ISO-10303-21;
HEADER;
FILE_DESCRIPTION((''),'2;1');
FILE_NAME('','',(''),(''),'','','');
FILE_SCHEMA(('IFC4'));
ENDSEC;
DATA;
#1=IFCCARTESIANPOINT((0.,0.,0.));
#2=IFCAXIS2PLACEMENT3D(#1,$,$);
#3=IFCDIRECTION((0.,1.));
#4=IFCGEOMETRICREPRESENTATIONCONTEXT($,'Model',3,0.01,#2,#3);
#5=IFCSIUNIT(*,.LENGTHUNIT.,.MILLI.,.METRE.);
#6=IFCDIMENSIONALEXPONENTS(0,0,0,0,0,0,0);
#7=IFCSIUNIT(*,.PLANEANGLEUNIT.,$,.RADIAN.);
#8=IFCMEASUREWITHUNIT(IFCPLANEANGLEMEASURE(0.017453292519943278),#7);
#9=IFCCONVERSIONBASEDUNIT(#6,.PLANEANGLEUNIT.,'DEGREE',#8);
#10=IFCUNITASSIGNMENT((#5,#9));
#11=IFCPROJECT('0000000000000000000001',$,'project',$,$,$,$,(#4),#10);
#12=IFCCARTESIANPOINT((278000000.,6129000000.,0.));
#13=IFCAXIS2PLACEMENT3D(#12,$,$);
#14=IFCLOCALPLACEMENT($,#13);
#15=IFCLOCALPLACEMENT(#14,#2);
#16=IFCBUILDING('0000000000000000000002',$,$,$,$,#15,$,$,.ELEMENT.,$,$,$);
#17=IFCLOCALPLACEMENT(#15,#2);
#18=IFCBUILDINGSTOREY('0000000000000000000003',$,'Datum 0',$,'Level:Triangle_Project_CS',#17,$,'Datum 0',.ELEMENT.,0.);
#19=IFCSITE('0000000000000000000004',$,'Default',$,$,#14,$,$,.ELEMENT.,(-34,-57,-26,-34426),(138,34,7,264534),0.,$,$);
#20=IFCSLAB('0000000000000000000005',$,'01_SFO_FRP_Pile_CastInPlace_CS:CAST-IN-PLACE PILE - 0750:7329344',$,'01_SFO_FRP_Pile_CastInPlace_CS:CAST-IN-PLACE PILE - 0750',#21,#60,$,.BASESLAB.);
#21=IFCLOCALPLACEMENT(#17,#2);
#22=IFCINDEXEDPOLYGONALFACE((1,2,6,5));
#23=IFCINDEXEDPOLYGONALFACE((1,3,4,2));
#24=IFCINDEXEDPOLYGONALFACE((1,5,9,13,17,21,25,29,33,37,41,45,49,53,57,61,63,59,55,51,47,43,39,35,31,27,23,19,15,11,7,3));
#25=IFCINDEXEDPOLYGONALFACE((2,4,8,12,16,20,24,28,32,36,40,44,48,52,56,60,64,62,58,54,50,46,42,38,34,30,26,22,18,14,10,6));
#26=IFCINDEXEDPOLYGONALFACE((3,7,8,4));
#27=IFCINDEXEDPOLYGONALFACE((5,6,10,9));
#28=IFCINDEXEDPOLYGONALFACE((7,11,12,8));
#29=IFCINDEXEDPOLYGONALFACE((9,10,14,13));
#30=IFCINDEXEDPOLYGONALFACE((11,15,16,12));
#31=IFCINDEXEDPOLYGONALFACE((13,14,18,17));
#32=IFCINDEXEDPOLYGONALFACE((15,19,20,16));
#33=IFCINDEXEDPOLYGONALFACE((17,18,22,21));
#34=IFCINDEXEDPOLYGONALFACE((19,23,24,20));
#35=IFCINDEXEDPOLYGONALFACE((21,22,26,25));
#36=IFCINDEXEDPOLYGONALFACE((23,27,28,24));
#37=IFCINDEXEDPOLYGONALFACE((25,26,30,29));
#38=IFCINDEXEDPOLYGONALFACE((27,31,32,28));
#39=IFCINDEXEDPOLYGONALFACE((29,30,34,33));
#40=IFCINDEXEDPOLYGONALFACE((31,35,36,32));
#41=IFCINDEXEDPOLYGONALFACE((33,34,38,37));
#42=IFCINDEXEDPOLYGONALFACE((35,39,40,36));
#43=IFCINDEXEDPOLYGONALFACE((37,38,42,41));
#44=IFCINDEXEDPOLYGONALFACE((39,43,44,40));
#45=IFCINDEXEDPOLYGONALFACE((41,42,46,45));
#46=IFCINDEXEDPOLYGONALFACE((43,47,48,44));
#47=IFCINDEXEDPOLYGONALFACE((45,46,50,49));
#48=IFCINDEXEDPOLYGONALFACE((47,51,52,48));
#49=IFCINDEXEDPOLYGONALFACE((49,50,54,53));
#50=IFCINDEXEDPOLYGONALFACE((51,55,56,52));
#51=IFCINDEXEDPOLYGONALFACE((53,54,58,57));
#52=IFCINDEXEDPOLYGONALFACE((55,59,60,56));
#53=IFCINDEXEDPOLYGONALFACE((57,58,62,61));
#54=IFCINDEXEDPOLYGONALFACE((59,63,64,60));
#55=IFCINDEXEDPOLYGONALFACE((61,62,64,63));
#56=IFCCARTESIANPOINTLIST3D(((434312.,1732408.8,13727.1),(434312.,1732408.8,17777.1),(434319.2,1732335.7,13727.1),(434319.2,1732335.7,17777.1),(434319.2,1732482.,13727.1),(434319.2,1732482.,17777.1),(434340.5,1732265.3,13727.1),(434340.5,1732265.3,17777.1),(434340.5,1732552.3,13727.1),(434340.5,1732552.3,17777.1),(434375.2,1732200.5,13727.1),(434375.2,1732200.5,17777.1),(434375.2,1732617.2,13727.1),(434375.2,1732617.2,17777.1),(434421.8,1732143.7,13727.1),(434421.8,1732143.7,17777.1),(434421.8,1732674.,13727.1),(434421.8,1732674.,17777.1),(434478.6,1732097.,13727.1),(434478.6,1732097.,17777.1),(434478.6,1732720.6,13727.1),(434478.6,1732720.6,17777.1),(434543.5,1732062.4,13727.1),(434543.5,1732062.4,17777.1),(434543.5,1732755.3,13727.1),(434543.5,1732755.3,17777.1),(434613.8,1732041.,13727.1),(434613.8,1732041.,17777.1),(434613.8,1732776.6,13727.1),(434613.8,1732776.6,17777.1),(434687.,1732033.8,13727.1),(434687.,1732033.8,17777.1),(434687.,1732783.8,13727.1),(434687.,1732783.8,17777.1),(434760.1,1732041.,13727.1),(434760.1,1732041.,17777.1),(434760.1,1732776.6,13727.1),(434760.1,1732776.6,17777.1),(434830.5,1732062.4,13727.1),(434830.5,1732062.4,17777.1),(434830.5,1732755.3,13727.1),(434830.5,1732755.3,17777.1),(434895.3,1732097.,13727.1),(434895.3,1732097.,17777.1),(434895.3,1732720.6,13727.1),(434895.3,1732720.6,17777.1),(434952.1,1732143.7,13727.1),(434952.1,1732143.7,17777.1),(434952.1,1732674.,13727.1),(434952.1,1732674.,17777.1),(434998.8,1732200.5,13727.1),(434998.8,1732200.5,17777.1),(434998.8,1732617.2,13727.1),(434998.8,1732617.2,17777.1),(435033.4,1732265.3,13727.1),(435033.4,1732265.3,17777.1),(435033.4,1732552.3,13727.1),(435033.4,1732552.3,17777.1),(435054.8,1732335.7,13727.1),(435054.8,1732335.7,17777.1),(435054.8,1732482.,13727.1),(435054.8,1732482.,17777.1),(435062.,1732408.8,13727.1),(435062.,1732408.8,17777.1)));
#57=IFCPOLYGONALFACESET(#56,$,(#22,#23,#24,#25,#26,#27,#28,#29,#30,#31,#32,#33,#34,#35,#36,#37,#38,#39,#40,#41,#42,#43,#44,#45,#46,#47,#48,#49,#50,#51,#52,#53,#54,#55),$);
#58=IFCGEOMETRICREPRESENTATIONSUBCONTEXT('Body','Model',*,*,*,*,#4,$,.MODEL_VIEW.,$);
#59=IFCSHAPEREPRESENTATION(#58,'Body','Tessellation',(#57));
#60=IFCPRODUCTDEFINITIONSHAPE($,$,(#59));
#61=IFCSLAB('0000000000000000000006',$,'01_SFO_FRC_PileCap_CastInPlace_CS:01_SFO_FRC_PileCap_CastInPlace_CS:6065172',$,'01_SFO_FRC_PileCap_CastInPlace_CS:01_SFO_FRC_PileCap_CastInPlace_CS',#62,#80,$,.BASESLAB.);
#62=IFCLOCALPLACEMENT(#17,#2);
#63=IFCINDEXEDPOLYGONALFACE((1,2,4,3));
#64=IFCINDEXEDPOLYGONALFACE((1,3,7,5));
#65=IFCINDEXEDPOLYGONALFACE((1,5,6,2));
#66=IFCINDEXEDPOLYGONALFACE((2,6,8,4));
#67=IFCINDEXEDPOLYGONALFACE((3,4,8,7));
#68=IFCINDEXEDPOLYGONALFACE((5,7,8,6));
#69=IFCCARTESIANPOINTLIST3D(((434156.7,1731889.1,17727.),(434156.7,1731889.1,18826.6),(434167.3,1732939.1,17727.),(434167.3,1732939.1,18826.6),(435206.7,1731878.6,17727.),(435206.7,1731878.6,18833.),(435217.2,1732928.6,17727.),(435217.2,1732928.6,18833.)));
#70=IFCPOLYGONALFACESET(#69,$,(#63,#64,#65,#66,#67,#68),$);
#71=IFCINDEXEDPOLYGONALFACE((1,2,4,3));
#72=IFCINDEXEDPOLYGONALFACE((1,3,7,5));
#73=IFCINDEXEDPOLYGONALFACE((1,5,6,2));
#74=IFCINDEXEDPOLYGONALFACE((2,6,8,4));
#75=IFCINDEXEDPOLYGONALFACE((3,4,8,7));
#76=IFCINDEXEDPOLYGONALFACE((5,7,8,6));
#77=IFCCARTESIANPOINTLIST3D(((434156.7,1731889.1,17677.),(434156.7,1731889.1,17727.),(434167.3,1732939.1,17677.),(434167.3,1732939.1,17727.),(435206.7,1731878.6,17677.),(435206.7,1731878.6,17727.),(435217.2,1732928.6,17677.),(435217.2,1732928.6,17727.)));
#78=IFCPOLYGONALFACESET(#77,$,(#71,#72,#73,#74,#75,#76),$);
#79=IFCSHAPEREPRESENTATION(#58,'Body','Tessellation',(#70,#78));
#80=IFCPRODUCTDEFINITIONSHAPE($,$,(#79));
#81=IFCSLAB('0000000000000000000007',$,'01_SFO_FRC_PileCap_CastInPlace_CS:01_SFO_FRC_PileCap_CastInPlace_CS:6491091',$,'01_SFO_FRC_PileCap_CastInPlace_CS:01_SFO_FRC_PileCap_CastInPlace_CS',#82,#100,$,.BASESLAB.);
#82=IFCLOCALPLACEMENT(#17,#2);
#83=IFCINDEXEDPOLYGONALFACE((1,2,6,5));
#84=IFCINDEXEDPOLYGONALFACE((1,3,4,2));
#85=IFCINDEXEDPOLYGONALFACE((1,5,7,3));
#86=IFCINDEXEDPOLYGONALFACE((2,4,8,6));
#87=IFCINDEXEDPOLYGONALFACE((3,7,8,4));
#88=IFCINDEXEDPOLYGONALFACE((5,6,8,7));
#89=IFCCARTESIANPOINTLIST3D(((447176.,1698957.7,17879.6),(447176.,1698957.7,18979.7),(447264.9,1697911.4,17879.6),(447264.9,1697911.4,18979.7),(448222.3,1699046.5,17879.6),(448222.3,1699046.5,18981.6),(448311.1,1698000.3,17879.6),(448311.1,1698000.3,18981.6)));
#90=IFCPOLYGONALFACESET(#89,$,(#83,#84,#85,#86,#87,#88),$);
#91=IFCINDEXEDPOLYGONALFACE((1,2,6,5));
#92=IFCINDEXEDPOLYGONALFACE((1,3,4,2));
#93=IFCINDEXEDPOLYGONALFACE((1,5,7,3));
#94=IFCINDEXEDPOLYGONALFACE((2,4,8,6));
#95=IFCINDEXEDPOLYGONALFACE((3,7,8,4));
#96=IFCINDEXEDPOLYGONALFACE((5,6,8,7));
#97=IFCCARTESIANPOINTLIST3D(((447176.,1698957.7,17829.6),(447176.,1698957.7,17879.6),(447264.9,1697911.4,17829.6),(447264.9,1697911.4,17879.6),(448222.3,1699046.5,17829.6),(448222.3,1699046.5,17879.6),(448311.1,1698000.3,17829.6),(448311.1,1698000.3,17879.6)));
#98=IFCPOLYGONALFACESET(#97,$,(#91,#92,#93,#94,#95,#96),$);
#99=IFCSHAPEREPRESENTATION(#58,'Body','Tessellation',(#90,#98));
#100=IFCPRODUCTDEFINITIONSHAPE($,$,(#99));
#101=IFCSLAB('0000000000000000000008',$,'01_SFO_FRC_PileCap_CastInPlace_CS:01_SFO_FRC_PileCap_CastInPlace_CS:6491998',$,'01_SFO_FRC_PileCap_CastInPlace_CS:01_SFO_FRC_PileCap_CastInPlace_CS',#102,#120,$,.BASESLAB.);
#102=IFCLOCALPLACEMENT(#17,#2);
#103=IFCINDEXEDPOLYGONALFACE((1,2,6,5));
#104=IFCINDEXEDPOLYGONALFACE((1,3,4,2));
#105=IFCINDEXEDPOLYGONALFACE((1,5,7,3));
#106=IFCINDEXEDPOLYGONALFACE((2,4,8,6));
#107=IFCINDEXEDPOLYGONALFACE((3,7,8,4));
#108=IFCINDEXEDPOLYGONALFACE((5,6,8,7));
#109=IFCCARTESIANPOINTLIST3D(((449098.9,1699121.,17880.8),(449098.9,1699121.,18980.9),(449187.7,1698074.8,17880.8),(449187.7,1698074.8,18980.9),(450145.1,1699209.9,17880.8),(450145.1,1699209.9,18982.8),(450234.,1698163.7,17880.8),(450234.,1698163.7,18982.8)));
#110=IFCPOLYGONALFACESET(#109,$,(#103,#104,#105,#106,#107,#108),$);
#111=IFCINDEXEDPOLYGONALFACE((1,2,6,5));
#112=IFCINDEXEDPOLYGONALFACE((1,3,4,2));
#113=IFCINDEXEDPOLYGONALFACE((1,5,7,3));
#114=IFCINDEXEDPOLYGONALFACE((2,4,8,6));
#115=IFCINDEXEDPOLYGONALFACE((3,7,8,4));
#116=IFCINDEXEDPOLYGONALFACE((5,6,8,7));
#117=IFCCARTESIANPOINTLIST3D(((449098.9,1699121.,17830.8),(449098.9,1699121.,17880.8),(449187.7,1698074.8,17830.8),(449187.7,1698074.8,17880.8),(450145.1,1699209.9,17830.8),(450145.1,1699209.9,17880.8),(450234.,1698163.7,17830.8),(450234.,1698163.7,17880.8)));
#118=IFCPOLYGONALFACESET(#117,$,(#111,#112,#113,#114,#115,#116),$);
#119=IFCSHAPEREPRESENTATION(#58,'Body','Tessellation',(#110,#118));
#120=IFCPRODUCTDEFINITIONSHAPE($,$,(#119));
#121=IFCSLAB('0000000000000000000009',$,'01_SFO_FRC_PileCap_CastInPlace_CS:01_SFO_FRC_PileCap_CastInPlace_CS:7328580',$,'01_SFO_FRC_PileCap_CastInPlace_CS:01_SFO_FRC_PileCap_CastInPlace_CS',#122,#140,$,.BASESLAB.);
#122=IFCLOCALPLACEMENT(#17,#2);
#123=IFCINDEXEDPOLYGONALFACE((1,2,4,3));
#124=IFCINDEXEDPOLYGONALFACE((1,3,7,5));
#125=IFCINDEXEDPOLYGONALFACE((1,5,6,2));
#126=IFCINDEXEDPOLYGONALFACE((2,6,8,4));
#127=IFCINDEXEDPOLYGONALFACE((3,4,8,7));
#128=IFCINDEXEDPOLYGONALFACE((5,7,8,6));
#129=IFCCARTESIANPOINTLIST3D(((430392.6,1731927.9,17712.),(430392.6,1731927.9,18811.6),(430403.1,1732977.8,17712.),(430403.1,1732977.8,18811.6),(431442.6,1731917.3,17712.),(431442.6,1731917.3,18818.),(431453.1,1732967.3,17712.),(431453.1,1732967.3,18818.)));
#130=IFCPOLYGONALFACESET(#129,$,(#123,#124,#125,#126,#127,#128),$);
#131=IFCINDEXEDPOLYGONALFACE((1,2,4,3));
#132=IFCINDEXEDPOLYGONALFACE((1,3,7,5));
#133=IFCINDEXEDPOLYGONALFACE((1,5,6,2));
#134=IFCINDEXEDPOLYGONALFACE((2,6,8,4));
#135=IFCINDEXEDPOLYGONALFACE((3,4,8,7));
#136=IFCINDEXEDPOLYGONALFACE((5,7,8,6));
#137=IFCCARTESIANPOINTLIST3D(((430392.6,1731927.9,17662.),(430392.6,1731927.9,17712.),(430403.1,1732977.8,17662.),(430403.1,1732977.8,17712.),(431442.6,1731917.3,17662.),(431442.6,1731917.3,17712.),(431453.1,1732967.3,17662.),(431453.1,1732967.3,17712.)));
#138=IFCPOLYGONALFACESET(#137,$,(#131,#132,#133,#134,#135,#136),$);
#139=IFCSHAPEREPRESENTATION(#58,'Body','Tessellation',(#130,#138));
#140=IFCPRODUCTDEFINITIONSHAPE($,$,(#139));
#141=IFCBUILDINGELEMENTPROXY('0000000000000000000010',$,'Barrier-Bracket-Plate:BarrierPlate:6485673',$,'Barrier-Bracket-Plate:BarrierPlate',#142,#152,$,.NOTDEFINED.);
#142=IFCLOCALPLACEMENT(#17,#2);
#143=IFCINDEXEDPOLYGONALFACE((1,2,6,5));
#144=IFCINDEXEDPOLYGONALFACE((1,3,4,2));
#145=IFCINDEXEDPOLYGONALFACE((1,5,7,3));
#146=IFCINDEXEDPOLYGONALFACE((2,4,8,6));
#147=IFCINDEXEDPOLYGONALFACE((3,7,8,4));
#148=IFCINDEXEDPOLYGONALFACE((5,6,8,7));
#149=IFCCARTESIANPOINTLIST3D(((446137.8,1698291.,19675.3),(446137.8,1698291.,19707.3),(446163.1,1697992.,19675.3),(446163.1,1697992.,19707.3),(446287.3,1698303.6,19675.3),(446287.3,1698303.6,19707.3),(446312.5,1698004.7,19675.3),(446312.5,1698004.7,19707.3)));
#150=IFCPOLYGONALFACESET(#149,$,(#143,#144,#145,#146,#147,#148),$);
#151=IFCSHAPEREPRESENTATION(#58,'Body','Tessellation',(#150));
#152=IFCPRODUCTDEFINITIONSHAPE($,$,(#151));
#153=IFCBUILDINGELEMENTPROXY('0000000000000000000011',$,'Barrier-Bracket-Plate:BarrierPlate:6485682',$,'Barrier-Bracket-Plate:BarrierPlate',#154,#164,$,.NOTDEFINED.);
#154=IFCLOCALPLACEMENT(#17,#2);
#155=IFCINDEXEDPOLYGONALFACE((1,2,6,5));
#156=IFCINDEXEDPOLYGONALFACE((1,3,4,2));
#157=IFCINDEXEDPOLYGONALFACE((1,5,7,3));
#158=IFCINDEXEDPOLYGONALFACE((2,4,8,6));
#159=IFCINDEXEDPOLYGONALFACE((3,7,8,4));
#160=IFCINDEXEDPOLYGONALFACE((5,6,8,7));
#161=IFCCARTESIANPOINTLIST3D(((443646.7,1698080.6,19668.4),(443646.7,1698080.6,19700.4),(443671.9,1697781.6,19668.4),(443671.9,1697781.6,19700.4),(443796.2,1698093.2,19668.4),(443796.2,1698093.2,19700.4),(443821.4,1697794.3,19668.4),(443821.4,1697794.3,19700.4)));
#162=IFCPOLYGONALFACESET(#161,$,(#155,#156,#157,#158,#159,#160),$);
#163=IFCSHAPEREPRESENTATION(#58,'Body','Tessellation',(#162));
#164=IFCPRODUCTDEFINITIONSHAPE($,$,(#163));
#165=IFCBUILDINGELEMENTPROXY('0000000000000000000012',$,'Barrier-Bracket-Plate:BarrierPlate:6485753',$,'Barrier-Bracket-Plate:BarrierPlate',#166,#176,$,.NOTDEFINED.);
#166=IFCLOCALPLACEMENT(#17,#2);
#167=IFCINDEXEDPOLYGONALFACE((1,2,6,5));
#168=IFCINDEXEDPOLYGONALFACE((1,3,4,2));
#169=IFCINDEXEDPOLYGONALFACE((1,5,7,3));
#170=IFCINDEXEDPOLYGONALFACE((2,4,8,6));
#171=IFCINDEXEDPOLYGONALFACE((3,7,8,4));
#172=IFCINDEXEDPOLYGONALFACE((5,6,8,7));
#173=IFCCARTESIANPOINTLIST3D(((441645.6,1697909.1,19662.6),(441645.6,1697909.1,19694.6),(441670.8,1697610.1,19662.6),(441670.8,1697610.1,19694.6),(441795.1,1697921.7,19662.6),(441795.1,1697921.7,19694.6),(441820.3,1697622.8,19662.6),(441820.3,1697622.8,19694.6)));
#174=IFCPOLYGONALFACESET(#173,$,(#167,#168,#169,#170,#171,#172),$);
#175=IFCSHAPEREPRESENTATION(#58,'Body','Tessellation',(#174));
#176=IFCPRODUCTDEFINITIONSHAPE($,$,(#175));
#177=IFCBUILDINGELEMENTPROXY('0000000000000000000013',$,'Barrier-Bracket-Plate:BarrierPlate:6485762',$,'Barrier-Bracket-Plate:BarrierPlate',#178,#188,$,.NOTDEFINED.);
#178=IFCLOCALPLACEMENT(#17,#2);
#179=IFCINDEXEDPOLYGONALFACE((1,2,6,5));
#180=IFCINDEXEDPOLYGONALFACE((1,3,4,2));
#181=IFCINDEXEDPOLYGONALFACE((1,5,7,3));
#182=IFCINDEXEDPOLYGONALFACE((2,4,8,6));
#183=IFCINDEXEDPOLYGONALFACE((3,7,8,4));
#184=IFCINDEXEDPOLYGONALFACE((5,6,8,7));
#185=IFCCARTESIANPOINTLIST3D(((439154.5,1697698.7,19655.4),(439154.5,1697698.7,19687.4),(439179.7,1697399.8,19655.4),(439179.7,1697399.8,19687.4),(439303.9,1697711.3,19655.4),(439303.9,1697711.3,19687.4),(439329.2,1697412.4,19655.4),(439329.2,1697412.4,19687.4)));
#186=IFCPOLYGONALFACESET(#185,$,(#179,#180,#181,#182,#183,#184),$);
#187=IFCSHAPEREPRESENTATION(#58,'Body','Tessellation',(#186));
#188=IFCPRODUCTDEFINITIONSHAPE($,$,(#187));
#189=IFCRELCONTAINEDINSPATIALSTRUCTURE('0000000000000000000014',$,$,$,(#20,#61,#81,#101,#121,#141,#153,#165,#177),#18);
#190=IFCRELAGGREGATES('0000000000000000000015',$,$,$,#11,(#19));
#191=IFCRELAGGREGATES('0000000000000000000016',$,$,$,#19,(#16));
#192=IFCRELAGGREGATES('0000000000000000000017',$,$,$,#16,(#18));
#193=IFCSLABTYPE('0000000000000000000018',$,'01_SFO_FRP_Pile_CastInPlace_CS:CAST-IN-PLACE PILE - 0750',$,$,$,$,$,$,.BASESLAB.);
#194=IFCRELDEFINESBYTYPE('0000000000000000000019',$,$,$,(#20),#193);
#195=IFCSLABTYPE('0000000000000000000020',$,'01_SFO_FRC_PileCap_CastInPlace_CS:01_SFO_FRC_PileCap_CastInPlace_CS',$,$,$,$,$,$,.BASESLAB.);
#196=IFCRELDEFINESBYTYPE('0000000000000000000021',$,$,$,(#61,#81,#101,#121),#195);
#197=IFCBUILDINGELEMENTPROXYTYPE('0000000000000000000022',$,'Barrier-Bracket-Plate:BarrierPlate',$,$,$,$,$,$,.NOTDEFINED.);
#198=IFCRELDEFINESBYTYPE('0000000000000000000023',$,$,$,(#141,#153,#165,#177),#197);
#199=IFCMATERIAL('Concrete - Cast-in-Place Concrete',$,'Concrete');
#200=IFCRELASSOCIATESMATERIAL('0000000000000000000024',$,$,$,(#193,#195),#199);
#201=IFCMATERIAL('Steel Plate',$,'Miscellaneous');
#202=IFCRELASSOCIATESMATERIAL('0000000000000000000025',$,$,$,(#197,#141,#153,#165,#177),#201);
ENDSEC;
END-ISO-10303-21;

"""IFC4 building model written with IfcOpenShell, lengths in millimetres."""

from ifc_helpers import new_model, entity, si_unit, converted_unit, direction, frame, origin, place, context, subcontext, project, spatial, arc, indexed_curve, outline, extrude, source, transform, mapped, material, type_object, type_shapes, element, save


model = new_model("IFC4")

# Units and contexts
model_context = context("Model", 3, precision=0.01, world=origin(), true_north=direction((0.0, 1.0)))
body_context = subcontext(model_context, "Body", "Model", "MODEL_VIEW")
ifc_project = project(units=[si_unit("LENGTHUNIT", "METRE", prefix="MILLI"), converted_unit("PLANEANGLEUNIT", "DEGREE", entity("IfcPlaneAngleMeasure", 0.017453292519943278), si_unit("PLANEANGLEUNIT", "RADIAN"), dimensions=[0, 0, 0, 0, 0, 0, 0])], contexts=[model_context])

# Site, building, storey
site_placement = place(None, frame((278000000.0, 6129000000.0, 0.0)))
site = spatial("IfcSite", under=ifc_project, at=site_placement, Name="Default", CompositionType="ELEMENT", RefLatitude=(-34, -57, -26, -34426), RefLongitude=(138, 34, 7, 264534), RefElevation=0.0)
building_placement = place(site_placement, origin())
building = spatial("IfcBuilding", under=site, at=building_placement, CompositionType="ELEMENT")
storey_placement = place(building_placement, frame((0.0, 0.0, 0.0)))
storey = spatial("IfcBuildingStorey", under=building, at=storey_placement, Name="Datum 0", ObjectType="Level:Triangle_Project_CS", LongName="Datum 0", CompositionType="ELEMENT", Elevation=0.0)

# Slabs
ifc_material_1 = material(Name="Concrete - Cast-in-Place Concrete", Category="Concrete")
slab_type_1 = type_object("IfcSlabType", Name="01_SFO_FRP_Pile_CastInPlace_CS:CAST-IN-PLACE PILE - 0750", PredefinedType="BASESLAB", material=ifc_material_1)
slab_1_placement = place(storey_placement, origin())
element("IfcSlab", 1, at=slab_1_placement, inside=storey, type_object=slab_type_1, Name="01_SFO_FRP_Pile_CastInPlace_CS:CAST-IN-PLACE PILE - 0750:7329344", ObjectType="01_SFO_FRP_Pile_CastInPlace_CS:CAST-IN-PLACE PILE - 0750", PredefinedType="BASESLAB", context=body_context, shape_type="SweptSolid", body=[
    extrude(outline(indexed_curve([(-375.0, 0.0), (0.0, -375.0), (375.0, 0.0), (0.0, 375.0)], segments=[arc(1, 2, 3), arc(3, 4, 1)], self_intersect=False)), frame((434687.0, 1732408.8, 13727.1), z_axis=(0.0, 0.0, 1.0), x_axis=(0.0, -1.0, 0.0)), (0.0, 0.0, 1.0), 4050.0),
])
slab_type_2 = type_object("IfcSlabType", Name="01_SFO_FRC_PileCap_CastInPlace_CS:01_SFO_FRC_PileCap_CastInPlace_CS", PredefinedType="BASESLAB", material=ifc_material_1)
slab_2_placement = place(storey_placement, origin())
element("IfcSlab", 2, at=slab_2_placement, inside=storey, type_object=slab_type_2, Name="01_SFO_FRC_PileCap_CastInPlace_CS:01_SFO_FRC_PileCap_CastInPlace_CS:6065172", ObjectType="01_SFO_FRC_PileCap_CastInPlace_CS:01_SFO_FRC_PileCap_CastInPlace_CS", PredefinedType="BASESLAB", context=body_context, shape_type="SweptSolid", body=[
    extrude(outline(indexed_curve([(-551.4, -525.0), (548.2, -525.0), (554.6, 525.0), (-551.4, 525.0), (-551.4, -525.0)], self_intersect=False)), frame((434681.7, 1731883.9, 18278.4), z_axis=(0.010008, 0.99995, 0.0), x_axis=(0.0, 0.0, 1.0)), (0.0, 0.0, 1.0), 1050.0),
    extrude(outline(indexed_curve([(-525.0, -525.0), (525.0, -525.0), (525.0, 525.0), (-525.0, 525.0), (-525.0, -525.0)], self_intersect=False)), frame((434687.0, 1732408.8, 17677.0), z_axis=(0.0, 0.0, 1.0), x_axis=(-0.010008, -0.99995, 0.0)), (0.0, 0.0, 1.0), 50.0),
])
slab_3_placement = place(storey_placement, origin())
element("IfcSlab", 3, at=slab_3_placement, inside=storey, type_object=slab_type_2, Name="01_SFO_FRC_PileCap_CastInPlace_CS:01_SFO_FRC_PileCap_CastInPlace_CS:6491091", ObjectType="01_SFO_FRC_PileCap_CastInPlace_CS:01_SFO_FRC_PileCap_CastInPlace_CS", PredefinedType="BASESLAB", context=body_context, shape_type="SweptSolid", body=[
    extrude(outline(indexed_curve([(-550.5, -525.0), (549.6, -525.0), (551.5, 525.0), (-550.5, 525.0), (-550.5, -525.0)], self_intersect=False)), frame((447788.0, 1697955.9, 18430.2), z_axis=(-0.084646, 0.996411, 0.0), x_axis=(0.0, 0.0, 1.0)), (0.0, 0.0, 1.0), 1050.0),
    extrude(outline(indexed_curve([(-525.0, -525.0), (525.0, -525.0), (525.0, 525.0), (-525.0, 525.0), (-525.0, -525.0)], self_intersect=False)), frame((447743.6, 1698479.0, 17829.6), z_axis=(0.0, 0.0, 1.0), x_axis=(0.084646, -0.996411, 0.0)), (0.0, 0.0, 1.0), 50.0),
])
slab_4_placement = place(storey_placement, origin())
element("IfcSlab", 4, at=slab_4_placement, inside=storey, type_object=slab_type_2, Name="01_SFO_FRC_PileCap_CastInPlace_CS:01_SFO_FRC_PileCap_CastInPlace_CS:6491998", ObjectType="01_SFO_FRC_PileCap_CastInPlace_CS:01_SFO_FRC_PileCap_CastInPlace_CS", PredefinedType="BASESLAB", context=body_context, shape_type="SweptSolid", body=[
    extrude(outline(indexed_curve([(-550.5, -525.0), (549.6, -525.0), (551.5, 525.0), (-550.5, 525.0), (-550.5, -525.0)], self_intersect=False)), frame((449710.9, 1698119.2, 18431.3), z_axis=(-0.084646, 0.996411, 0.0), x_axis=(0.0, 0.0, 1.0)), (0.0, 0.0, 1.0), 1050.0),
    extrude(outline(indexed_curve([(-525.0, -525.0), (525.0, -525.0), (525.0, 525.0), (-525.0, 525.0), (-525.0, -525.0)], self_intersect=False)), frame((449666.4, 1698642.3, 17830.8), z_axis=(0.0, 0.0, 1.0), x_axis=(0.084646, -0.996411, 0.0)), (0.0, 0.0, 1.0), 50.0),
])
slab_5_placement = place(storey_placement, origin())
element("IfcSlab", 5, at=slab_5_placement, inside=storey, type_object=slab_type_2, Name="01_SFO_FRC_PileCap_CastInPlace_CS:01_SFO_FRC_PileCap_CastInPlace_CS:7328580", ObjectType="01_SFO_FRC_PileCap_CastInPlace_CS:01_SFO_FRC_PileCap_CastInPlace_CS", PredefinedType="BASESLAB", context=body_context, shape_type="SweptSolid", body=[
    extrude(outline(indexed_curve([(-551.4, -525.0), (548.2, -525.0), (554.6, 525.0), (-551.4, 525.0), (-551.4, -525.0)], self_intersect=False)), frame((430917.6, 1731922.6, 18263.4), z_axis=(0.010009, 0.99995, 0.0), x_axis=(0.0, 0.0, 1.0)), (0.0, 0.0, 1.0), 1050.0),
    extrude(outline(indexed_curve([(-525.0, -525.0), (525.0, -525.0), (525.0, 525.0), (-525.0, 525.0), (-525.0, -525.0)], self_intersect=False)), frame((430922.9, 1732447.6, 17662.0), z_axis=(0.0, 0.0, 1.0), x_axis=(-0.010009, -0.99995, 0.0)), (0.0, 0.0, 1.0), 50.0),
])

# Building element proxies
ifc_material_2 = material(Name="Steel Plate", Category="Miscellaneous")
building_element_proxy_type_1 = type_object("IfcBuildingElementProxyType", Name="Barrier-Bracket-Plate:BarrierPlate", PredefinedType="NOTDEFINED", material=ifc_material_2)
shared_shape_1 = source(origin(), body_context, "Body", "SweptSolid", [
    extrude(outline(indexed_curve([(-150.0, -75.0), (150.0, -75.0), (150.0, 75.0), (-150.0, 75.0), (-150.0, -75.0)], self_intersect=False)), frame((-150.0, 0.0, 0.0), z_axis=(0.0, 0.0, 1.0), x_axis=(-1.0, 0.0, 0.0)), (0.0, 0.0, 1.0), 32.0),
])
type_shapes(building_element_proxy_type_1, [shared_shape_1])
for number, where, z_axis, x_axis, name in (
    (6, (446212.6, 1698297.3, 19675.3), (0.0, 0.0, 1.0), (-0.084154, 0.996453, 0.0), "Barrier-Bracket-Plate:BarrierPlate:6485673"),
    (7, (443721.4, 1698086.9, 19668.4), (0.0, 0.0, 1.0), (-0.084154, 0.996453, 0.0), "Barrier-Bracket-Plate:BarrierPlate:6485682"),
    (8, (441720.3, 1697915.4, 19662.6), (0.0, 0.0, 1.0), (-0.084154, 0.996453, 0.0), "Barrier-Bracket-Plate:BarrierPlate:6485753"),
    (9, (439229.2, 1697705.0, 19655.4), (0.0, 0.0, 1.0), (-0.084154, 0.996453, 0.0), "Barrier-Bracket-Plate:BarrierPlate:6485762"),
):
    element("IfcBuildingElementProxy", number, at=place(storey_placement, frame(where, z_axis=z_axis, x_axis=x_axis)), inside=storey, type_object=building_element_proxy_type_1, material=ifc_material_2, Name=name, ObjectType="Barrier-Bracket-Plate:BarrierPlate", PredefinedType="NOTDEFINED", context=body_context, shape_type="MappedRepresentation", body=[
        mapped(shared_shape_1, transform((0.0, 0.0, 0.0), scale=1.0)),
    ])

save(model, "model.ifc")
